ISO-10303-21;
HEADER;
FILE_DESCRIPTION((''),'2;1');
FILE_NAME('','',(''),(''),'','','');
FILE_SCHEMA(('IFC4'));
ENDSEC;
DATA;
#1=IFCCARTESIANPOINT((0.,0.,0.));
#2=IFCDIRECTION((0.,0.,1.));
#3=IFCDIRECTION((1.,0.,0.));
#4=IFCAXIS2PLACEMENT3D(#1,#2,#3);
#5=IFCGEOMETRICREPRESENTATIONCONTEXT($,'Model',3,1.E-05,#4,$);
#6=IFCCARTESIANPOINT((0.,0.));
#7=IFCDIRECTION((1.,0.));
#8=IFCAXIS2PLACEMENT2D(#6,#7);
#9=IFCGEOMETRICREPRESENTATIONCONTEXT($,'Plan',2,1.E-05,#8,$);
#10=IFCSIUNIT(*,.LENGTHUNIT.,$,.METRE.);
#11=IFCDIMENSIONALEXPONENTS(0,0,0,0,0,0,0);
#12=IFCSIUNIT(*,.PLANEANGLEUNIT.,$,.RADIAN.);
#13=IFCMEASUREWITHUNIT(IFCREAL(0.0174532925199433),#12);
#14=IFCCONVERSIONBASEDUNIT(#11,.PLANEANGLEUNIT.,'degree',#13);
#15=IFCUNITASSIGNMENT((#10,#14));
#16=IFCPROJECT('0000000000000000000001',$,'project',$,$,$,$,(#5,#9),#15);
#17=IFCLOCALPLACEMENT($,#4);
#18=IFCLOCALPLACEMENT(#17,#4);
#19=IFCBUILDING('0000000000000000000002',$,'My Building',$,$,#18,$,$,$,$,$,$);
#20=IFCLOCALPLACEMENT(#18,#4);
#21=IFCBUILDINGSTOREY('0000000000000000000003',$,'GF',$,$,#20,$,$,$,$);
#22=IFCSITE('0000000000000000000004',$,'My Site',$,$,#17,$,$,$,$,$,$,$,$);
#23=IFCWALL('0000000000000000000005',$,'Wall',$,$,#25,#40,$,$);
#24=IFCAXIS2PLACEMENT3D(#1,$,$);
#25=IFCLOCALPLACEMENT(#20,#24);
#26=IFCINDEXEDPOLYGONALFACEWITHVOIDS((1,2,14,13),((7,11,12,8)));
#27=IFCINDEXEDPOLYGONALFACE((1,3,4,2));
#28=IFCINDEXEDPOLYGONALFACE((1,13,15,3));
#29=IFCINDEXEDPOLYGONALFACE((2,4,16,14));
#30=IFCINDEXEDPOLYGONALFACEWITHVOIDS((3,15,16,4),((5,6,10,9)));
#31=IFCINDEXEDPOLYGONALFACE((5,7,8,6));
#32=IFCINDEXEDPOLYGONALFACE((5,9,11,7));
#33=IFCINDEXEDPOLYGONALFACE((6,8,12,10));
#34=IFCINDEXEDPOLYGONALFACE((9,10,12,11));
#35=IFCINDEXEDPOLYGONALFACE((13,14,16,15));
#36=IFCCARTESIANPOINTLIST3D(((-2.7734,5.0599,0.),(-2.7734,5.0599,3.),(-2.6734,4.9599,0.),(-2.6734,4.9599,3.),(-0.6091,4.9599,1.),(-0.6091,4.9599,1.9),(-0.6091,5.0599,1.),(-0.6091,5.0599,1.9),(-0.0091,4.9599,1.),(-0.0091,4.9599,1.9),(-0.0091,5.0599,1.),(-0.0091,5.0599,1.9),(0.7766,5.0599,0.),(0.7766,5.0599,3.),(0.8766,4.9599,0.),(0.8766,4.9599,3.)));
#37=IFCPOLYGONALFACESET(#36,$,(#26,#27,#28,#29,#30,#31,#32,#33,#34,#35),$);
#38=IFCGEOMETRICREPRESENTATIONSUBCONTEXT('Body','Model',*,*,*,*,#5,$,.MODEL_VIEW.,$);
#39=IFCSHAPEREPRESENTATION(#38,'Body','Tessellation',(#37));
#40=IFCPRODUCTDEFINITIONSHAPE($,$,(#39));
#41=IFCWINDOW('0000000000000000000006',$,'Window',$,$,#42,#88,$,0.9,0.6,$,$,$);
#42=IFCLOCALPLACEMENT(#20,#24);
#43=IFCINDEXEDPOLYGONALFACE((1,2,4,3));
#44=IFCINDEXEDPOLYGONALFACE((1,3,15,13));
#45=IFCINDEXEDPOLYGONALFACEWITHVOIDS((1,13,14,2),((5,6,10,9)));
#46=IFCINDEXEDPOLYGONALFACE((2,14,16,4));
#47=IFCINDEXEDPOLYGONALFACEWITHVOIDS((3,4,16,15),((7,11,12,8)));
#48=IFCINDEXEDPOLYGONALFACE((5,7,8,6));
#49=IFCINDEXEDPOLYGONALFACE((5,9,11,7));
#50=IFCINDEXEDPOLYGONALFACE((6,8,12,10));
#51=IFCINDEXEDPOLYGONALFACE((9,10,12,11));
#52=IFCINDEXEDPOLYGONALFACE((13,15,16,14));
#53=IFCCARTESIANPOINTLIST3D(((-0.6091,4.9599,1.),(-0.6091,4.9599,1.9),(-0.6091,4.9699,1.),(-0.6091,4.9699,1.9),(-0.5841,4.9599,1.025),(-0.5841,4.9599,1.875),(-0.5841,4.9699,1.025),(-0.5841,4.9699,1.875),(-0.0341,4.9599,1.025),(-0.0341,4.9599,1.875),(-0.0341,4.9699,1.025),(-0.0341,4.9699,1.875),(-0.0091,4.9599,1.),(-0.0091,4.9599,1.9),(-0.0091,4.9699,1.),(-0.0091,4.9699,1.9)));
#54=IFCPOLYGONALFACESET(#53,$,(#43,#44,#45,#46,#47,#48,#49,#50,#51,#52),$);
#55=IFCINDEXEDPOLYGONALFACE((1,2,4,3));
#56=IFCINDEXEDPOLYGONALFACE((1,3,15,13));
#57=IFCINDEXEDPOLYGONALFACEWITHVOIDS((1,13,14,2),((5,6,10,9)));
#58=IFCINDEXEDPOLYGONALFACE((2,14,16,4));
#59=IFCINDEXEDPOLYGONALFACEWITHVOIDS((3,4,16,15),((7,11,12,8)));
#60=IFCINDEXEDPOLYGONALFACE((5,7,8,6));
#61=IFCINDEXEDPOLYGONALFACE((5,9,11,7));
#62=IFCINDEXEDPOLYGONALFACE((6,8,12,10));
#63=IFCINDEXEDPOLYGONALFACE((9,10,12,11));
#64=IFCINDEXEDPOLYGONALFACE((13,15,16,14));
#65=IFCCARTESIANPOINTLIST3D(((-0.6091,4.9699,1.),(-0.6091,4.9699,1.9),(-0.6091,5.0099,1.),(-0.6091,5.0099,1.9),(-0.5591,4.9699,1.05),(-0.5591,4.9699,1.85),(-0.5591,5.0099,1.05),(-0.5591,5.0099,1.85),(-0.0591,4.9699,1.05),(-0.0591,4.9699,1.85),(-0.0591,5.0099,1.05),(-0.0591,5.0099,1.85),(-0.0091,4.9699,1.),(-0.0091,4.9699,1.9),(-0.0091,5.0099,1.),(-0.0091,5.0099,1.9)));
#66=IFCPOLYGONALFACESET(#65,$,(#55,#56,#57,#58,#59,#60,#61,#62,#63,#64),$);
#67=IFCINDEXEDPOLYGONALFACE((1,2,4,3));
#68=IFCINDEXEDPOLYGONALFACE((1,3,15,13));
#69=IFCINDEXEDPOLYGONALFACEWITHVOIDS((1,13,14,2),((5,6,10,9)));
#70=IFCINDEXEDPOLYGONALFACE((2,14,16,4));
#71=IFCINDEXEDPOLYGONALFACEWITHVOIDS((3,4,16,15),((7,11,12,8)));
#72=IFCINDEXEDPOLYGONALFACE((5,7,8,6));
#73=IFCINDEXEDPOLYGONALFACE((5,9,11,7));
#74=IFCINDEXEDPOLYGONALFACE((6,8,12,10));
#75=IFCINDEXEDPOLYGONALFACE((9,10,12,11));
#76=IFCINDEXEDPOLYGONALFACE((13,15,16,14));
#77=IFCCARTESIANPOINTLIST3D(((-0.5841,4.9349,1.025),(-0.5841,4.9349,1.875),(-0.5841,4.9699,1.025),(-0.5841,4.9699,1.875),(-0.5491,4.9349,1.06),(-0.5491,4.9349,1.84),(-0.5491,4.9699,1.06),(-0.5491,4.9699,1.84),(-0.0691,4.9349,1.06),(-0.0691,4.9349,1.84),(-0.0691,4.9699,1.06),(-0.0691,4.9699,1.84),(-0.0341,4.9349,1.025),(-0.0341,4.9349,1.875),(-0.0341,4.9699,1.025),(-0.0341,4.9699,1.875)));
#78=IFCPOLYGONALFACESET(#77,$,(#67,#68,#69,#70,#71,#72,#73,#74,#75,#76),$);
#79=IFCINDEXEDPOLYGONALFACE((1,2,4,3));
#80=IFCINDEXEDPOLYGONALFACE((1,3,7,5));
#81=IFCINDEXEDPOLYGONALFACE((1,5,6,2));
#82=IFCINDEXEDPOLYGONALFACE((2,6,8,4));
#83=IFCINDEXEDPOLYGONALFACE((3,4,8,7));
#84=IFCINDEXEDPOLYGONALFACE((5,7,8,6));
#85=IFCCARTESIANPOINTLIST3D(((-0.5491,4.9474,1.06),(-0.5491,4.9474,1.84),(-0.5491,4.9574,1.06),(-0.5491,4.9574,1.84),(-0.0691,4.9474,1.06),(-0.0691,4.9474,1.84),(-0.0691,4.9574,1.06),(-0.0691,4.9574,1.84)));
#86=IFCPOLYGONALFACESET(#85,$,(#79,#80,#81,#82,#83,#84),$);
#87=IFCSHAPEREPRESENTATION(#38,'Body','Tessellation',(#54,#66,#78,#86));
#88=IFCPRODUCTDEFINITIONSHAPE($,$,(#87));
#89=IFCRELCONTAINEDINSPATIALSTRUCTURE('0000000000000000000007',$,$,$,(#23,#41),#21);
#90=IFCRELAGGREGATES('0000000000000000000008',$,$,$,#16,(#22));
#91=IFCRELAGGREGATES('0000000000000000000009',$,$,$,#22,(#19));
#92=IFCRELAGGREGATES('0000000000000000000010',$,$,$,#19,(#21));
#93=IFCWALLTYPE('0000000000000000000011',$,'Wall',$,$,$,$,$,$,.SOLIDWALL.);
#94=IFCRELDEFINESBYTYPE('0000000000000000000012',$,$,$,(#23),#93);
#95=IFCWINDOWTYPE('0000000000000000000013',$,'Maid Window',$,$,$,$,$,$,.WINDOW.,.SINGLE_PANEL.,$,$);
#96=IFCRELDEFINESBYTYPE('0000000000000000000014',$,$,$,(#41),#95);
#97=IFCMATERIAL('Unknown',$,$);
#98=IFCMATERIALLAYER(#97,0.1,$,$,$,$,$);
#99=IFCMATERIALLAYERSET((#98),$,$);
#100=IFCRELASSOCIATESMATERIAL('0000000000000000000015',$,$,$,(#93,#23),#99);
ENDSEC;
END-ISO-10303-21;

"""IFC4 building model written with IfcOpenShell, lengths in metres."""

from ifc_helpers import new_model, entity, si_unit, converted_unit, frame, origin_with_axes, origin_2d_with_axis, place, context, subcontext, project, spatial, line, indexed_curve, outline, extrude, shape, source, transform, mapped, material, layer, layer_set, layer_usage, type_object, type_shapes, element, fill, save


model = new_model("IFC4")

# Units and contexts
model_context = context("Model", 3, precision=1e-05, world=origin_with_axes())
plan_context = context("Plan", 2, precision=1e-05, world=origin_2d_with_axis())
body_context_1 = subcontext(model_context, "Body", "Model", "MODEL_VIEW")
body_context_2 = subcontext(plan_context, "Body", "Plan", "PLAN_VIEW")
ifc_project = project(units=[si_unit("LENGTHUNIT", "METRE"), converted_unit("PLANEANGLEUNIT", "degree", entity("IfcReal", 0.0174532925199433), si_unit("PLANEANGLEUNIT", "RADIAN"), dimensions=[0, 0, 0, 0, 0, 0, 0])], contexts=[model_context, plan_context])

# Site, building, storey
site_placement = place(None, origin_with_axes())
site = spatial("IfcSite", under=ifc_project, at=site_placement, Name="My Site")
building_placement = place(site_placement, origin_with_axes())
building = spatial("IfcBuilding", under=site, at=building_placement, Name="My Building")
storey_placement = place(building_placement, origin_with_axes())
storey = spatial("IfcBuildingStorey", under=building, at=storey_placement, Name="GF")

# Shared definitions
ifc_material = material(Name="Unknown")

# Shared definitions
ifc_layer = layer(ifc_material, 0.1)
ifc_layer_set = layer_set([ifc_layer])
wall_type = type_object("IfcWallType", Name="Wall", PredefinedType="SOLIDWALL", material=ifc_layer_set)

# Wall, opening, window
ifc_layer_usage_1 = layer_usage(ifc_layer_set, "AXIS2", "POSITIVE", 0.0)
wall_1_placement = place(storey_placement, frame((0.7766, 5.0599, 0.0), z_axis=(0.0, 0.0, 1.0), x_axis=(-1.0, 0.0, 0.0)))
wall_1 = element("IfcWall", 1, at=wall_1_placement, inside=storey, type_object=wall_type, material=ifc_layer_usage_1, Name="Wall", context=body_context_1, shape_type="SweptSolid", body=[
    extrude(outline(indexed_curve([(0.0, 0.0), (-0.1, 0.1), (3.45, 0.1), (3.55, 0.0)], segments=[line(1, 2, 3, 4, 1)])), origin_with_axes(), (0.0, 0.0, 1.0), 3.0),
])
shared_shape_1 = source(origin_with_axes(), body_context_1, "Body", "SweptSolid", [
    extrude(outline(indexed_curve([(0.0, 0.0), (0.6, 0.0), (0.6, 0.9), (0.0, 0.9)], segments=[line(1, 2, 3, 4, 1)])), frame((0.0, -0.6, 0.0), z_axis=(0.0, -1.0, 0.0), x_axis=(1.0, 0.0, 0.0)), (0.0, 0.0, -1.0), 1.2),
])
opening_1_placement = place(wall_1_placement, frame((0.7857, 0.0, 1.0), z_axis=(0.0, 0.0, 1.0), x_axis=(1.0, 0.0, 0.0)))
opening_1 = element("IfcOpeningElement", 2, at=opening_1_placement, cuts=wall_1, PredefinedType="OPENING", context=body_context_1, shape_type="MappedRepresentation", body=[
    mapped(shared_shape_1, transform((0.0, 0.0, 0.0), x_axis=(1.0, 0.0, 0.0), y_axis=(0.0, 1.0, 0.0), z_axis=(0.0, 0.0, 1.0), scale=1.0)),
])
window_type_1 = type_object("IfcWindowType", Name="Maid Window", PartitioningType="SINGLE_PANEL", PredefinedType="WINDOW")
shared_shape_2 = source(origin_with_axes(), body_context_1, "Body", "SweptSolid", [
    extrude(outline(indexed_curve([(0.0, 0.0), (0.6, 0.0), (0.6, 0.9), (0.0, 0.9)], segments=[line(1, 2, 3, 4, 1)]), holes=[indexed_curve([(0.025, 0.025), (0.575, 0.025), (0.575, 0.875), (0.025, 0.875)], segments=[line(1, 2, 3, 4, 1)])]), frame((0.0, 0.09, 0.0), z_axis=(0.0, -1.0, 0.0), x_axis=(1.0, 0.0, 0.0)), (0.0, 0.0, -1.0), 0.01),
    extrude(outline(indexed_curve([(0.0, 0.0), (0.6, 0.0), (0.6, 0.9), (0.0, 0.9)], segments=[line(1, 2, 3, 4, 1)]), holes=[indexed_curve([(0.05, 0.05), (0.55, 0.05), (0.55, 0.85), (0.05, 0.85)], segments=[line(1, 2, 3, 4, 1)])]), frame((0.0, 0.05, 0.0), z_axis=(0.0, -1.0, 0.0), x_axis=(1.0, 0.0, 0.0)), (0.0, 0.0, -1.0), 0.04),
    extrude(outline(indexed_curve([(0.0, 0.0), (0.55, 0.0), (0.55, 0.85), (0.0, 0.85)], segments=[line(1, 2, 3, 4, 1)]), holes=[indexed_curve([(0.035, 0.035), (0.515, 0.035), (0.515, 0.815), (0.035, 0.815)], segments=[line(1, 2, 3, 4, 1)])]), frame((0.025, 0.09, 0.025), z_axis=(0.0, -1.0, 0.0), x_axis=(1.0, 0.0, 0.0)), (0.0, 0.0, -1.0), 0.035),
    extrude(outline(indexed_curve([(0.035, 0.035), (0.515, 0.035), (0.515, 0.815), (0.035, 0.815)], segments=[line(1, 2, 3, 4, 1)])), frame((0.025, 0.1025, 0.025), z_axis=(0.0, -1.0, 0.0), x_axis=(1.0, 0.0, 0.0)), (0.0, 0.0, -1.0), 0.01),
])
shared_shape_3 = source(origin_with_axes(), body_context_2, "Body", "Curve2D", [
    entity("IfcIndexedPolyCurve", entity("IfcCartesianPointList2D", [[0.05, 0.05], [0.55, 0.05]])),
    entity("IfcIndexedPolyCurve", entity("IfcCartesianPointList2D", [[0.0, 0.1], [0.025, 0.1], [0.025, 0.09], [0.05, 0.09], [0.05, 0.05], [0.0, 0.05]]), [entity("IfcLineIndex", [1, 2, 3, 4, 5, 6, 1])]),
    entity("IfcIndexedPolyCurve", entity("IfcCartesianPointList2D", [[0.6, 0.1], [0.575, 0.1], [0.575, 0.09], [0.55, 0.09], [0.55, 0.05], [0.6, 0.05]]), [entity("IfcLineIndex", [1, 2, 3, 4, 5, 6, 1])]),
    entity("IfcIndexedPolyCurve", entity("IfcCartesianPointList2D", [[0.025, 0.09], [0.06, 0.09], [0.06, 0.125], [0.025, 0.125]]), [entity("IfcLineIndex", [1, 2, 3, 4, 1])]),
    entity("IfcIndexedPolyCurve", entity("IfcCartesianPointList2D", [[0.575, 0.09], [0.54, 0.09], [0.54, 0.125], [0.575, 0.125]]), [entity("IfcLineIndex", [1, 2, 3, 4, 1])]),
    entity("IfcIndexedPolyCurve", entity("IfcCartesianPointList2D", [[0.06, 0.09], [0.54, 0.09]])),
    entity("IfcIndexedPolyCurve", entity("IfcCartesianPointList2D", [[0.06, 0.125], [0.54, 0.125]])),
    entity("IfcIndexedPolyCurve", entity("IfcCartesianPointList2D", [[0.06, 0.1075], [0.54, 0.1075]])),
])
type_shapes(window_type_1, [shared_shape_2, shared_shape_3])
window_1_placement = place(opening_1_placement, frame((0.0, 0.0, 0.0), z_axis=(0.0, 0.0, 1.0), x_axis=(1.0, 0.0, 0.0)))
window_1 = element("IfcWindow", 3, at=window_1_placement, inside=storey, type_object=window_type_1, Name="Window", OverallHeight=0.9, OverallWidth=0.6, shapes=[
    shape(body_context_1, "Body", "MappedRepresentation", [mapped(shared_shape_2, transform((0.0, 0.0, 0.0), x_axis=(1.0, 0.0, 0.0), y_axis=(0.0, 1.0, 0.0), z_axis=(0.0, 0.0, 1.0), scale=1.0))]),
    shape(body_context_2, "Body", "MappedRepresentation", [mapped(shared_shape_3, transform((0.0, 0.0, 0.0), x_axis=(1.0, 0.0, 0.0), y_axis=(0.0, 1.0, 0.0), z_axis=(0.0, 0.0, 1.0), scale=1.0))]),
])
fill(opening_1, window_1)

save(model, "model.ifc")
